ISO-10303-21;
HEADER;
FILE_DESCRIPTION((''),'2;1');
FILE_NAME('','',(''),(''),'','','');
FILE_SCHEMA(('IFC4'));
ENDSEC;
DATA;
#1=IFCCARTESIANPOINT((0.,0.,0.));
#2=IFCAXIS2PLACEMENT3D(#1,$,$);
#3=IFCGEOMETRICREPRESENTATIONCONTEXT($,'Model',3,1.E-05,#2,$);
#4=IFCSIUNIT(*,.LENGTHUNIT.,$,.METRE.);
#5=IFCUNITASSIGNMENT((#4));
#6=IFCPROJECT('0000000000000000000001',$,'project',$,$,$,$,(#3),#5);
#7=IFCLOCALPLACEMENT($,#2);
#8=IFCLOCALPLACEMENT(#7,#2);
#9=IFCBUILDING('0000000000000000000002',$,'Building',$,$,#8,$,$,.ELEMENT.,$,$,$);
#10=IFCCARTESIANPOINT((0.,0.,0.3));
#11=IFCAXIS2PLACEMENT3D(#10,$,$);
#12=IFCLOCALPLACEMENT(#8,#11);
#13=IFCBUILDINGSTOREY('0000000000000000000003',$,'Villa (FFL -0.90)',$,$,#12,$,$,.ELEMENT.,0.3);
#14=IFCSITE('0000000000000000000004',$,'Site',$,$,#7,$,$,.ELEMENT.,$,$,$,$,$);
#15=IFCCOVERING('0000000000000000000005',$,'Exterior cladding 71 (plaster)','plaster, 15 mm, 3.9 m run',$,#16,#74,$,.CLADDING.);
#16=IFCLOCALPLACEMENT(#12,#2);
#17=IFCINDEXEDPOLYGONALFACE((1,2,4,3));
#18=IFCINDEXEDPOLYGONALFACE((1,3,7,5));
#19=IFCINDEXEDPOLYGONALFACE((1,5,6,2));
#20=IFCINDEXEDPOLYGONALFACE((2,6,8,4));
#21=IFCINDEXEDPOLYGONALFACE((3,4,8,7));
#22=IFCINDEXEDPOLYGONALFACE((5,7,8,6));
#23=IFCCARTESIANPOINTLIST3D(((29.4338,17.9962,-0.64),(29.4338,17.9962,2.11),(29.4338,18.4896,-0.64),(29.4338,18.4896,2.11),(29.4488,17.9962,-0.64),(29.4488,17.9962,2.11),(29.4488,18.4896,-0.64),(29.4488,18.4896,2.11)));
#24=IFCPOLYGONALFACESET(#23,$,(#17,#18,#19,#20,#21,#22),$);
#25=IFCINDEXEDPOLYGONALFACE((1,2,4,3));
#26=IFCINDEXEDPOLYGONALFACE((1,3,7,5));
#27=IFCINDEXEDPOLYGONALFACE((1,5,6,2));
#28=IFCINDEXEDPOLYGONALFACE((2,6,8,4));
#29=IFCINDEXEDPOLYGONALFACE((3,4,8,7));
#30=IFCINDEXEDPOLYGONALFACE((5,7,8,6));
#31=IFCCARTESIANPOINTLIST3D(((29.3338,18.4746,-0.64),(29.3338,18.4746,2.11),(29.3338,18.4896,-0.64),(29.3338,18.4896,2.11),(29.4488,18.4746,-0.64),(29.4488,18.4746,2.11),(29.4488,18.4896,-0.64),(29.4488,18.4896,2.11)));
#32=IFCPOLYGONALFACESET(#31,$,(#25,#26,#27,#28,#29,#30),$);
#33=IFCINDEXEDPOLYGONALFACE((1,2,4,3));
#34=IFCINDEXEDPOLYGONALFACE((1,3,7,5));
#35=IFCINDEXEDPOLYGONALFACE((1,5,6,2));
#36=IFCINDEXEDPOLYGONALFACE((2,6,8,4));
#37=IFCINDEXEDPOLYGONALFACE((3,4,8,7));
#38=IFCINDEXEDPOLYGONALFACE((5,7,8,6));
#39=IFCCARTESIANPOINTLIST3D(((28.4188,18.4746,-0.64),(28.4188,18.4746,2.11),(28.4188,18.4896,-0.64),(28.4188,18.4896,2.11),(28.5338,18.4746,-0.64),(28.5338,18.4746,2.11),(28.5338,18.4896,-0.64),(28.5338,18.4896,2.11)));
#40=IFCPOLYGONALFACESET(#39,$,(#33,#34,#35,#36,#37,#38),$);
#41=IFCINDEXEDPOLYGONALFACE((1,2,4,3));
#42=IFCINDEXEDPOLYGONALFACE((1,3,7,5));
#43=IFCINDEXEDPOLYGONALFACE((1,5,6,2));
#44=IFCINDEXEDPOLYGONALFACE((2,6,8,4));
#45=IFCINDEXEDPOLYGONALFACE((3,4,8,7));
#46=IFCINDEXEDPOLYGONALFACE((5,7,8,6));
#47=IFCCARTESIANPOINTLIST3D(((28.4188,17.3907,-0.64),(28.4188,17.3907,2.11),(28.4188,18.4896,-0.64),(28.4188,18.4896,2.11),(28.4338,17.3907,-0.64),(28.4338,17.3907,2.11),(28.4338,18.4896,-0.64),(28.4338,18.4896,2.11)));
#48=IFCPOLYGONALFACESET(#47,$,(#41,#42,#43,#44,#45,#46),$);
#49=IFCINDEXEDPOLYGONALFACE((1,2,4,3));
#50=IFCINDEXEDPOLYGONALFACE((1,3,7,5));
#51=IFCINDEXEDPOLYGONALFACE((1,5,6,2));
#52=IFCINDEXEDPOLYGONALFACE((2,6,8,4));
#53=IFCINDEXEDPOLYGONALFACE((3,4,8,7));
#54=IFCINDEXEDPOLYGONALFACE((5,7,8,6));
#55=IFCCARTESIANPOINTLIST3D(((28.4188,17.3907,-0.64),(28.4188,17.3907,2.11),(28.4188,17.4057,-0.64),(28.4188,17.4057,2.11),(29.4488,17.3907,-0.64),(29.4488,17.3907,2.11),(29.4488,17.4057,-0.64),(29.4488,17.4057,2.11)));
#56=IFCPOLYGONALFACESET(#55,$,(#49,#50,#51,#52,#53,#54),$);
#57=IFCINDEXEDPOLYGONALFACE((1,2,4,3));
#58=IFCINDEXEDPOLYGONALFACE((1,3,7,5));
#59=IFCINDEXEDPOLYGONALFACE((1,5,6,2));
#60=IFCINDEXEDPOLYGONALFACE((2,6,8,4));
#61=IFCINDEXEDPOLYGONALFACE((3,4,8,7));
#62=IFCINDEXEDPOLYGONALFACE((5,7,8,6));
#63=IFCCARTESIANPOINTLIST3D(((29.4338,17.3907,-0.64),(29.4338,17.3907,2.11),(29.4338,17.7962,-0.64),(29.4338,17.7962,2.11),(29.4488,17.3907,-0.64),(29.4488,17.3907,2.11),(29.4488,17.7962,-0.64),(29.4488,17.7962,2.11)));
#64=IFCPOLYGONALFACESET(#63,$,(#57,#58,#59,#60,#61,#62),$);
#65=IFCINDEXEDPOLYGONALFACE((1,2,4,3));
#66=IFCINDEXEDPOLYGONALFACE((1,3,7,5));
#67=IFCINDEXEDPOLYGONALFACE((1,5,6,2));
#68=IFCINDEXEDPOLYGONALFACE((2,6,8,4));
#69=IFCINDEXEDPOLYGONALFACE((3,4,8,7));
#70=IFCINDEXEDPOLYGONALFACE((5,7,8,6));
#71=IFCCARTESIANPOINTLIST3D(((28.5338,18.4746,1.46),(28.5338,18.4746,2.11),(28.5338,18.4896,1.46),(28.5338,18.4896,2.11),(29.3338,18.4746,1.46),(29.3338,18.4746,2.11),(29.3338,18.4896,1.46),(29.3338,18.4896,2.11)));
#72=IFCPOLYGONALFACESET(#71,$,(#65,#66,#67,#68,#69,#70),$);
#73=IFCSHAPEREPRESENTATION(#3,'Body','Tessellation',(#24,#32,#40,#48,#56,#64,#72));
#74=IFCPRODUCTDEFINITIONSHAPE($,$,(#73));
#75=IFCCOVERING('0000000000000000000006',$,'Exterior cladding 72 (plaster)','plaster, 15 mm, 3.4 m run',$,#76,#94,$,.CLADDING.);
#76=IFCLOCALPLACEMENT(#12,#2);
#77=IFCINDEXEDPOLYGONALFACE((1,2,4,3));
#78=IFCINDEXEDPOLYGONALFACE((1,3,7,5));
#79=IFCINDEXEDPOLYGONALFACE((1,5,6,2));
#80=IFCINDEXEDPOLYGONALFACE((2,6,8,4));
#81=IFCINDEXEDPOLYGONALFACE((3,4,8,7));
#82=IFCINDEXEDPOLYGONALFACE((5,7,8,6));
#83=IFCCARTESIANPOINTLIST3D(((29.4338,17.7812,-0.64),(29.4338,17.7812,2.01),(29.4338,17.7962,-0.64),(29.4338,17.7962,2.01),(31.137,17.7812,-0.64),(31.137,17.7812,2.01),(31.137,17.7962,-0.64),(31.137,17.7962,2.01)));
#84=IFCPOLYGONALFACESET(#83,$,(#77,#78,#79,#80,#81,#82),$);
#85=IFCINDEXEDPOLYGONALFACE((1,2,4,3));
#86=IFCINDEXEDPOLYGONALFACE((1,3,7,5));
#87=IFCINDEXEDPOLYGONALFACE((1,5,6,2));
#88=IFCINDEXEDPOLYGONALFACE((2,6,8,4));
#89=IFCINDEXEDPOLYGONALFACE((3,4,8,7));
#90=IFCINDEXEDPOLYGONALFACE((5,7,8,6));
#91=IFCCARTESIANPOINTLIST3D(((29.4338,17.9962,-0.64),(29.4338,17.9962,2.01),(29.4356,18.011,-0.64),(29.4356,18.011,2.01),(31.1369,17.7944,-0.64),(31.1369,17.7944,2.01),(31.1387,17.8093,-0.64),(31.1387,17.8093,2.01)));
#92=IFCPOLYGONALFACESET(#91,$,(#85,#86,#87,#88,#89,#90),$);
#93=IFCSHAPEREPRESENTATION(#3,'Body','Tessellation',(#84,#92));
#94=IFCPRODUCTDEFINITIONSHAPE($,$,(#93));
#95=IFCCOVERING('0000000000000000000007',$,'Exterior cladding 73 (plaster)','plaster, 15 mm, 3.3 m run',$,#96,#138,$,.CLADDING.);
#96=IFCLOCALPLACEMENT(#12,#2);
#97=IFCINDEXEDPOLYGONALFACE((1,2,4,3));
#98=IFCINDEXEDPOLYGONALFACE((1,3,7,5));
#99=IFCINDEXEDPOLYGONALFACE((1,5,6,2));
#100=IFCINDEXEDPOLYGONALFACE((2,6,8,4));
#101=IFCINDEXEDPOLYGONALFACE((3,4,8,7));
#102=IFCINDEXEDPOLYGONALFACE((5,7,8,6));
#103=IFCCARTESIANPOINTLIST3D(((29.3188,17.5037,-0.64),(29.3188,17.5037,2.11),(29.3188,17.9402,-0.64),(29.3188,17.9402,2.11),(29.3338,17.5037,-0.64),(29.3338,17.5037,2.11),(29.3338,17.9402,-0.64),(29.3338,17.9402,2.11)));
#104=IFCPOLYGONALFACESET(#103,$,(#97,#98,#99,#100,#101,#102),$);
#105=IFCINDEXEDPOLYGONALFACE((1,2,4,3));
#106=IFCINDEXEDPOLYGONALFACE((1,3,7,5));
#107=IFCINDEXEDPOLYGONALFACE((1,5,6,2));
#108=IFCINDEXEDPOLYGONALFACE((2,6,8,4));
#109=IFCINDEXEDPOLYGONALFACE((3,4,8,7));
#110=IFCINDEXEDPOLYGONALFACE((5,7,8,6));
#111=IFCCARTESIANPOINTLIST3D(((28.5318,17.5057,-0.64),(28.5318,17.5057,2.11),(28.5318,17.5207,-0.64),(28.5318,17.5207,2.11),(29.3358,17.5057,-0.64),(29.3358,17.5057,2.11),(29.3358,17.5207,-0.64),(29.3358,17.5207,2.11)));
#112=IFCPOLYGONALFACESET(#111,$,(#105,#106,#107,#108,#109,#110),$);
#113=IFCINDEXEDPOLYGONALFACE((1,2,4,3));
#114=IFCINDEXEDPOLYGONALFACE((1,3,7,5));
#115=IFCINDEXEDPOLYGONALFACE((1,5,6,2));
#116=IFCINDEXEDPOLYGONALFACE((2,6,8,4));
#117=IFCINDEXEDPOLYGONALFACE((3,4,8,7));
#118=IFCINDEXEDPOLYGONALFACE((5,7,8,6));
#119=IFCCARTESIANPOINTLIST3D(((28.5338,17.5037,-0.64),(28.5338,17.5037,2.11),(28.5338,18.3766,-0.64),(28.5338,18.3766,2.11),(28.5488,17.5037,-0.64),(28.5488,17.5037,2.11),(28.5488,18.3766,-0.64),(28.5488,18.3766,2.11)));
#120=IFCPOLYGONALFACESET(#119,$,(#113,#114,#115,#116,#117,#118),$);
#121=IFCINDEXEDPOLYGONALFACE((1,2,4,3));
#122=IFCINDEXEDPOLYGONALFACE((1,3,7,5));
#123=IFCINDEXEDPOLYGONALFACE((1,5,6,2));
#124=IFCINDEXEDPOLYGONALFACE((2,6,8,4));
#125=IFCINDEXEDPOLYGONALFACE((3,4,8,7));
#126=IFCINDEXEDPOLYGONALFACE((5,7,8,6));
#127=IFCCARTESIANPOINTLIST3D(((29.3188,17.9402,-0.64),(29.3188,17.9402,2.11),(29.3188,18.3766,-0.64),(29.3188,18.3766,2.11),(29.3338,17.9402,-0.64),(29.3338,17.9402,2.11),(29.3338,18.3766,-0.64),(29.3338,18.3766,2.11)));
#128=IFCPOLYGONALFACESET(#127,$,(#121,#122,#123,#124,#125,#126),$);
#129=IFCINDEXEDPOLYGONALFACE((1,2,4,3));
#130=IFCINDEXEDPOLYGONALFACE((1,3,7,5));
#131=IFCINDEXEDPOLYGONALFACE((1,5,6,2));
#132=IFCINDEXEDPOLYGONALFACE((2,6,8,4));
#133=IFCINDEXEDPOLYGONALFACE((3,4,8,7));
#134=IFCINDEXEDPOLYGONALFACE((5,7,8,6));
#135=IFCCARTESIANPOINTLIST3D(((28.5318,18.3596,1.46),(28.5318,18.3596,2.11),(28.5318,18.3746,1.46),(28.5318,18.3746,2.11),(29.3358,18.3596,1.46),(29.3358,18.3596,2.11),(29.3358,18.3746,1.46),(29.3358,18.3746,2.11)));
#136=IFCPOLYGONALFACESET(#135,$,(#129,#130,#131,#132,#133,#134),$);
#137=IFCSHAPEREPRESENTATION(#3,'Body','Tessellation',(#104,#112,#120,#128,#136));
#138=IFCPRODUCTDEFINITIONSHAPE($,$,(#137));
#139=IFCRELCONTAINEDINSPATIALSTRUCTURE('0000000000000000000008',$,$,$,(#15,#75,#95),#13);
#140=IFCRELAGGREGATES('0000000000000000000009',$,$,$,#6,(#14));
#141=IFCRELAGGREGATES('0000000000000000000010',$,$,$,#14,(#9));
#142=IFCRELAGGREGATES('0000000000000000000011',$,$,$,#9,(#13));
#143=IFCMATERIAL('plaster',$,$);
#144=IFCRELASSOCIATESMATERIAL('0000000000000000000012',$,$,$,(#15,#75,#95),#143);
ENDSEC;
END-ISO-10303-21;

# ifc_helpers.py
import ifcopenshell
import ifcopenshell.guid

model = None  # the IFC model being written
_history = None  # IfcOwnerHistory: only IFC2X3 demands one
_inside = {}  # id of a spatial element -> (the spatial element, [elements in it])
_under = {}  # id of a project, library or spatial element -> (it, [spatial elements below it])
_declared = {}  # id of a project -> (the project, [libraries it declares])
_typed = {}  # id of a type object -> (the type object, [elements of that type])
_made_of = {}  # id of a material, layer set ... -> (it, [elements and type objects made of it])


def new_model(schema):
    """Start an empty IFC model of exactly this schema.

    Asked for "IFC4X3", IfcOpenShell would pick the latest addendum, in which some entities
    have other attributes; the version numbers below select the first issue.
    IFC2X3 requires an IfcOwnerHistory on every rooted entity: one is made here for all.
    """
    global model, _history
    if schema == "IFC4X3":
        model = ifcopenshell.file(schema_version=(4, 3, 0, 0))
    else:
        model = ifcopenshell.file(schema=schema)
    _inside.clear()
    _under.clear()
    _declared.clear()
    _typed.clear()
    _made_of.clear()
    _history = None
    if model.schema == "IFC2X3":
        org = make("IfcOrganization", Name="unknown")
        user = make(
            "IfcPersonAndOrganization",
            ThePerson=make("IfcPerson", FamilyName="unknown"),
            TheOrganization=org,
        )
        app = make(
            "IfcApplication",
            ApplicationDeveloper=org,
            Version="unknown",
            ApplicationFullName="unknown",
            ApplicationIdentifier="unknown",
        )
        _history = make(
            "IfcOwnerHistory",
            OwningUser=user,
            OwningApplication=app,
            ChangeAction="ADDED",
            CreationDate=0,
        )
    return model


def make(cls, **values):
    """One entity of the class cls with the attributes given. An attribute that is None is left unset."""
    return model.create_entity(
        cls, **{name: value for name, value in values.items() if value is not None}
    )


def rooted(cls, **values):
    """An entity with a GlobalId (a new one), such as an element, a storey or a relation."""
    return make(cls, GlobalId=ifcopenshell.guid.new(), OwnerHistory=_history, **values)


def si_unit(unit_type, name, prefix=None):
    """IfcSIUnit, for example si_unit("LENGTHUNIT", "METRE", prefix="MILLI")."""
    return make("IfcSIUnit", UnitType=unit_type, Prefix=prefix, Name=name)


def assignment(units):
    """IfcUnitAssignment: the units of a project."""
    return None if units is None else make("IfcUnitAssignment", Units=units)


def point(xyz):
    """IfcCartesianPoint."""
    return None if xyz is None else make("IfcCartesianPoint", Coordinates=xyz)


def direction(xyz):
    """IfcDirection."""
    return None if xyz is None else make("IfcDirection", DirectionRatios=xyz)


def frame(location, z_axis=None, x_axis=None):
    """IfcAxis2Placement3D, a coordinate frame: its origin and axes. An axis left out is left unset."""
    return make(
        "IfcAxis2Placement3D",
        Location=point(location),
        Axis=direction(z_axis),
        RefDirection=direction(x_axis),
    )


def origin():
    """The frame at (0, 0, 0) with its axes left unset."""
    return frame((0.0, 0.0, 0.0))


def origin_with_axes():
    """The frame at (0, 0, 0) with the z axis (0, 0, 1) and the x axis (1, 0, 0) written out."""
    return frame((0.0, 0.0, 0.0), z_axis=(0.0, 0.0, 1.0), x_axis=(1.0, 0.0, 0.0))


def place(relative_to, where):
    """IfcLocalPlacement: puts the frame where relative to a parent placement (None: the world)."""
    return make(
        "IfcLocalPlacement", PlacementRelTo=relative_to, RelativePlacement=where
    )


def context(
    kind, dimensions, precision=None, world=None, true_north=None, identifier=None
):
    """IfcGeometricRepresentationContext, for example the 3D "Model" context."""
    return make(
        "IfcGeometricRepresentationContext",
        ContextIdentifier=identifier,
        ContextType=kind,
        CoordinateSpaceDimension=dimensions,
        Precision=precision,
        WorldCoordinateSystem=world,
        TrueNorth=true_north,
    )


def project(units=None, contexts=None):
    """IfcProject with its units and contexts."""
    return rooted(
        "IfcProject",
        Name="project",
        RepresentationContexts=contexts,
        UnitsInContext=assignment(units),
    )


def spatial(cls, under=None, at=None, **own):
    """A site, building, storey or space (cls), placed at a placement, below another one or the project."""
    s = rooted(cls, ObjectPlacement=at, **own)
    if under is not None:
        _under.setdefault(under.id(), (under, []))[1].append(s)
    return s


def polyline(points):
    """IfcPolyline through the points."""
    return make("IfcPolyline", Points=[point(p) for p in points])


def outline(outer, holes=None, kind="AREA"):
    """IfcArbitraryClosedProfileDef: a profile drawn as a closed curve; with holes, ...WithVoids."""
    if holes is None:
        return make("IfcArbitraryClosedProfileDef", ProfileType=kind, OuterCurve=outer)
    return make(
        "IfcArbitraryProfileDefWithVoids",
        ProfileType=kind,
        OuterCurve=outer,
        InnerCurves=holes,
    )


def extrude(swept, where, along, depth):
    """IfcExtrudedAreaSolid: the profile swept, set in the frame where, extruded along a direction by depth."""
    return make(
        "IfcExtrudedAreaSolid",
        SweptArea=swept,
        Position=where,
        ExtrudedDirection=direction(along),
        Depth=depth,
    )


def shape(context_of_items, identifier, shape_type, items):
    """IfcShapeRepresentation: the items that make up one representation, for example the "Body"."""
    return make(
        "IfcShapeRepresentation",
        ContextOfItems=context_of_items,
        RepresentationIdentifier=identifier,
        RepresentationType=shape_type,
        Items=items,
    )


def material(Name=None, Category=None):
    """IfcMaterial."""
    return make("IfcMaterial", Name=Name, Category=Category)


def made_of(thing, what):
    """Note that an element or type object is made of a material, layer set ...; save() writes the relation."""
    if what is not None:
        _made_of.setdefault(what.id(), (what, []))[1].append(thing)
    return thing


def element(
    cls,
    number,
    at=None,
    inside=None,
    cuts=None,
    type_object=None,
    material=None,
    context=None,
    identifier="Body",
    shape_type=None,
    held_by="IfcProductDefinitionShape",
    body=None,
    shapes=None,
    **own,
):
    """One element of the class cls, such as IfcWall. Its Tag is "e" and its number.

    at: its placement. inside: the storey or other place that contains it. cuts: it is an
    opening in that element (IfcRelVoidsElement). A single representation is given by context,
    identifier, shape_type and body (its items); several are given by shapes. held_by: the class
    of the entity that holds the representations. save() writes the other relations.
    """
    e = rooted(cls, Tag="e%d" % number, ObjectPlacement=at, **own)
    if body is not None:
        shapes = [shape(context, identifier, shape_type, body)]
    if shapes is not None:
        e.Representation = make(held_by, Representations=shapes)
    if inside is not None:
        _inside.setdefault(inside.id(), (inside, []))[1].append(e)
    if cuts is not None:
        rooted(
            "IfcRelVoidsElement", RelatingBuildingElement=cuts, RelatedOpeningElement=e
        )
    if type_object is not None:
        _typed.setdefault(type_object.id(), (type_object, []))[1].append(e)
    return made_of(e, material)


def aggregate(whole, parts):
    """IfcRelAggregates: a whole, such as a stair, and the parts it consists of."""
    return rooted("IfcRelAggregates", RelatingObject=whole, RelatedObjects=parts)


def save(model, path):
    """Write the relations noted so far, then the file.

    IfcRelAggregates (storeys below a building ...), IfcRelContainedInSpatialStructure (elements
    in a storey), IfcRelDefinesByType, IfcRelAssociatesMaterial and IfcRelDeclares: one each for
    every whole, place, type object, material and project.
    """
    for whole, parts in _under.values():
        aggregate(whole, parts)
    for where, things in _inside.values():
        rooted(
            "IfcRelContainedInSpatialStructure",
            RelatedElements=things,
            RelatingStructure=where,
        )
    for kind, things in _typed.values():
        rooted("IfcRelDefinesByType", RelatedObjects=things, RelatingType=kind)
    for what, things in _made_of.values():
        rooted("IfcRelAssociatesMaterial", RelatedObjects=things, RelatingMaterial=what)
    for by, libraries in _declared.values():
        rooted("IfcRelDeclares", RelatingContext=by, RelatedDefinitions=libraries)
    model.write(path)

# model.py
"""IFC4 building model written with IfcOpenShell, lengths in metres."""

from ifc_helpers import new_model, si_unit, frame, origin, origin_with_axes, place, context, project, spatial, polyline, outline, extrude, material, element, save


model = new_model("IFC4")

# Units and contexts
model_context = context("Model", 3, precision=1e-05, world=origin())
ifc_project = project(units=[si_unit("LENGTHUNIT", "METRE")], contexts=[model_context])

# Site, building, storey
site_placement = place(None, origin())
site = spatial("IfcSite", under=ifc_project, at=site_placement, Name="Site", CompositionType="ELEMENT")
building_placement = place(site_placement, origin())
building = spatial("IfcBuilding", under=site, at=building_placement, Name="Building", CompositionType="ELEMENT")
storey_placement = place(building_placement, frame((0.0, 0.0, 0.3)))
storey = spatial("IfcBuildingStorey", under=building, at=storey_placement, Name="Villa (FFL -0.90)", CompositionType="ELEMENT", Elevation=0.3)

# Coverings
ifc_material = material(Name="plaster")
covering_1_placement = place(storey_placement, origin_with_axes())
element("IfcCovering", 1, at=covering_1_placement, inside=storey, material=ifc_material, Name="Exterior cladding 71 (plaster)", Description="plaster, 15 mm, 3.9 m run", PredefinedType="CLADDING", context=model_context, shape_type="SweptSolid", body=[
    extrude(outline(polyline([(29.4488, 17.9962), (29.4488, 18.4896), (29.4338, 18.4896), (29.4338, 17.9962), (29.4488, 17.9962)])), frame((0.0, 0.0, -0.64)), (0.0, 0.0, 1.0), 2.75),
    extrude(outline(polyline([(29.4488, 18.4896), (29.3338, 18.4896), (29.3338, 18.4746), (29.4488, 18.4746), (29.4488, 18.4896)])), frame((0.0, 0.0, -0.64)), (0.0, 0.0, 1.0), 2.75),
    extrude(outline(polyline([(28.5338, 18.4896), (28.4188, 18.4896), (28.4188, 18.4746), (28.5338, 18.4746), (28.5338, 18.4896)])), frame((0.0, 0.0, -0.64)), (0.0, 0.0, 1.0), 2.75),
    extrude(outline(polyline([(28.4188, 18.4896), (28.4188, 17.3907), (28.4338, 17.3907), (28.4338, 18.4896), (28.4188, 18.4896)])), frame((0.0, 0.0, -0.64)), (0.0, 0.0, 1.0), 2.75),
    extrude(outline(polyline([(28.4188, 17.3907), (29.4488, 17.3907), (29.4488, 17.4057), (28.4188, 17.4057), (28.4188, 17.3907)])), frame((0.0, 0.0, -0.64)), (0.0, 0.0, 1.0), 2.75),
    extrude(outline(polyline([(29.4488, 17.3907), (29.4488, 17.7962), (29.4338, 17.7962), (29.4338, 17.3907), (29.4488, 17.3907)])), frame((0.0, 0.0, -0.64)), (0.0, 0.0, 1.0), 2.75),
    extrude(outline(polyline([(29.3338, 18.4896), (28.5338, 18.4896), (28.5338, 18.4746), (29.3338, 18.4746), (29.3338, 18.4896)])), frame((0.0, 0.0, 1.46)), (0.0, 0.0, 1.0), 0.65),
])
covering_2_placement = place(storey_placement, origin_with_axes())
element("IfcCovering", 2, at=covering_2_placement, inside=storey, material=ifc_material, Name="Exterior cladding 72 (plaster)", Description="plaster, 15 mm, 3.4 m run", PredefinedType="CLADDING", context=model_context, shape_type="SweptSolid", body=[
    extrude(outline(polyline([(29.4338, 17.7812), (31.137, 17.7812), (31.137, 17.7962), (29.4338, 17.7962), (29.4338, 17.7812)])), frame((0.0, 0.0, -0.64)), (0.0, 0.0, 1.0), 2.65),
    extrude(outline(polyline([(31.1387, 17.8093), (29.4356, 18.011), (29.4338, 17.9962), (31.1369, 17.7944), (31.1387, 17.8093)])), frame((0.0, 0.0, -0.64)), (0.0, 0.0, 1.0), 2.65),
])
covering_3_placement = place(storey_placement, origin_with_axes())
element("IfcCovering", 3, at=covering_3_placement, inside=storey, material=ifc_material, Name="Exterior cladding 73 (plaster)", Description="plaster, 15 mm, 3.3 m run", PredefinedType="CLADDING", context=model_context, shape_type="SweptSolid", body=[
    extrude(outline(polyline([(29.3188, 17.9401), (29.3188, 17.5037), (29.3338, 17.5037), (29.3338, 17.9401), (29.3188, 17.9401)])), frame((0.0, 0.0, -0.64)), (0.0, 0.0, 1.0), 2.75),
    extrude(outline(polyline([(29.3358, 17.5207), (28.5318, 17.5207), (28.5318, 17.5057), (29.3358, 17.5057), (29.3358, 17.5207)])), frame((0.0, 0.0, -0.64)), (0.0, 0.0, 1.0), 2.75),
    extrude(outline(polyline([(28.5488, 17.5037), (28.5488, 18.3766), (28.5338, 18.3766), (28.5338, 17.5037), (28.5488, 17.5037)])), frame((0.0, 0.0, -0.64)), (0.0, 0.0, 1.0), 2.75),
    extrude(outline(polyline([(29.3188, 18.3766), (29.3188, 17.9401), (29.3338, 17.9401), (29.3338, 18.3766), (29.3188, 18.3766)])), frame((0.0, 0.0, -0.64)), (0.0, 0.0, 1.0), 2.75),
    extrude(outline(polyline([(28.5318, 18.3596), (29.3358, 18.3596), (29.3358, 18.3746), (28.5318, 18.3746), (28.5318, 18.3596)])), frame((0.0, 0.0, 1.46)), (0.0, 0.0, 1.0), 0.65),
])

save(model, "model.ifc")
